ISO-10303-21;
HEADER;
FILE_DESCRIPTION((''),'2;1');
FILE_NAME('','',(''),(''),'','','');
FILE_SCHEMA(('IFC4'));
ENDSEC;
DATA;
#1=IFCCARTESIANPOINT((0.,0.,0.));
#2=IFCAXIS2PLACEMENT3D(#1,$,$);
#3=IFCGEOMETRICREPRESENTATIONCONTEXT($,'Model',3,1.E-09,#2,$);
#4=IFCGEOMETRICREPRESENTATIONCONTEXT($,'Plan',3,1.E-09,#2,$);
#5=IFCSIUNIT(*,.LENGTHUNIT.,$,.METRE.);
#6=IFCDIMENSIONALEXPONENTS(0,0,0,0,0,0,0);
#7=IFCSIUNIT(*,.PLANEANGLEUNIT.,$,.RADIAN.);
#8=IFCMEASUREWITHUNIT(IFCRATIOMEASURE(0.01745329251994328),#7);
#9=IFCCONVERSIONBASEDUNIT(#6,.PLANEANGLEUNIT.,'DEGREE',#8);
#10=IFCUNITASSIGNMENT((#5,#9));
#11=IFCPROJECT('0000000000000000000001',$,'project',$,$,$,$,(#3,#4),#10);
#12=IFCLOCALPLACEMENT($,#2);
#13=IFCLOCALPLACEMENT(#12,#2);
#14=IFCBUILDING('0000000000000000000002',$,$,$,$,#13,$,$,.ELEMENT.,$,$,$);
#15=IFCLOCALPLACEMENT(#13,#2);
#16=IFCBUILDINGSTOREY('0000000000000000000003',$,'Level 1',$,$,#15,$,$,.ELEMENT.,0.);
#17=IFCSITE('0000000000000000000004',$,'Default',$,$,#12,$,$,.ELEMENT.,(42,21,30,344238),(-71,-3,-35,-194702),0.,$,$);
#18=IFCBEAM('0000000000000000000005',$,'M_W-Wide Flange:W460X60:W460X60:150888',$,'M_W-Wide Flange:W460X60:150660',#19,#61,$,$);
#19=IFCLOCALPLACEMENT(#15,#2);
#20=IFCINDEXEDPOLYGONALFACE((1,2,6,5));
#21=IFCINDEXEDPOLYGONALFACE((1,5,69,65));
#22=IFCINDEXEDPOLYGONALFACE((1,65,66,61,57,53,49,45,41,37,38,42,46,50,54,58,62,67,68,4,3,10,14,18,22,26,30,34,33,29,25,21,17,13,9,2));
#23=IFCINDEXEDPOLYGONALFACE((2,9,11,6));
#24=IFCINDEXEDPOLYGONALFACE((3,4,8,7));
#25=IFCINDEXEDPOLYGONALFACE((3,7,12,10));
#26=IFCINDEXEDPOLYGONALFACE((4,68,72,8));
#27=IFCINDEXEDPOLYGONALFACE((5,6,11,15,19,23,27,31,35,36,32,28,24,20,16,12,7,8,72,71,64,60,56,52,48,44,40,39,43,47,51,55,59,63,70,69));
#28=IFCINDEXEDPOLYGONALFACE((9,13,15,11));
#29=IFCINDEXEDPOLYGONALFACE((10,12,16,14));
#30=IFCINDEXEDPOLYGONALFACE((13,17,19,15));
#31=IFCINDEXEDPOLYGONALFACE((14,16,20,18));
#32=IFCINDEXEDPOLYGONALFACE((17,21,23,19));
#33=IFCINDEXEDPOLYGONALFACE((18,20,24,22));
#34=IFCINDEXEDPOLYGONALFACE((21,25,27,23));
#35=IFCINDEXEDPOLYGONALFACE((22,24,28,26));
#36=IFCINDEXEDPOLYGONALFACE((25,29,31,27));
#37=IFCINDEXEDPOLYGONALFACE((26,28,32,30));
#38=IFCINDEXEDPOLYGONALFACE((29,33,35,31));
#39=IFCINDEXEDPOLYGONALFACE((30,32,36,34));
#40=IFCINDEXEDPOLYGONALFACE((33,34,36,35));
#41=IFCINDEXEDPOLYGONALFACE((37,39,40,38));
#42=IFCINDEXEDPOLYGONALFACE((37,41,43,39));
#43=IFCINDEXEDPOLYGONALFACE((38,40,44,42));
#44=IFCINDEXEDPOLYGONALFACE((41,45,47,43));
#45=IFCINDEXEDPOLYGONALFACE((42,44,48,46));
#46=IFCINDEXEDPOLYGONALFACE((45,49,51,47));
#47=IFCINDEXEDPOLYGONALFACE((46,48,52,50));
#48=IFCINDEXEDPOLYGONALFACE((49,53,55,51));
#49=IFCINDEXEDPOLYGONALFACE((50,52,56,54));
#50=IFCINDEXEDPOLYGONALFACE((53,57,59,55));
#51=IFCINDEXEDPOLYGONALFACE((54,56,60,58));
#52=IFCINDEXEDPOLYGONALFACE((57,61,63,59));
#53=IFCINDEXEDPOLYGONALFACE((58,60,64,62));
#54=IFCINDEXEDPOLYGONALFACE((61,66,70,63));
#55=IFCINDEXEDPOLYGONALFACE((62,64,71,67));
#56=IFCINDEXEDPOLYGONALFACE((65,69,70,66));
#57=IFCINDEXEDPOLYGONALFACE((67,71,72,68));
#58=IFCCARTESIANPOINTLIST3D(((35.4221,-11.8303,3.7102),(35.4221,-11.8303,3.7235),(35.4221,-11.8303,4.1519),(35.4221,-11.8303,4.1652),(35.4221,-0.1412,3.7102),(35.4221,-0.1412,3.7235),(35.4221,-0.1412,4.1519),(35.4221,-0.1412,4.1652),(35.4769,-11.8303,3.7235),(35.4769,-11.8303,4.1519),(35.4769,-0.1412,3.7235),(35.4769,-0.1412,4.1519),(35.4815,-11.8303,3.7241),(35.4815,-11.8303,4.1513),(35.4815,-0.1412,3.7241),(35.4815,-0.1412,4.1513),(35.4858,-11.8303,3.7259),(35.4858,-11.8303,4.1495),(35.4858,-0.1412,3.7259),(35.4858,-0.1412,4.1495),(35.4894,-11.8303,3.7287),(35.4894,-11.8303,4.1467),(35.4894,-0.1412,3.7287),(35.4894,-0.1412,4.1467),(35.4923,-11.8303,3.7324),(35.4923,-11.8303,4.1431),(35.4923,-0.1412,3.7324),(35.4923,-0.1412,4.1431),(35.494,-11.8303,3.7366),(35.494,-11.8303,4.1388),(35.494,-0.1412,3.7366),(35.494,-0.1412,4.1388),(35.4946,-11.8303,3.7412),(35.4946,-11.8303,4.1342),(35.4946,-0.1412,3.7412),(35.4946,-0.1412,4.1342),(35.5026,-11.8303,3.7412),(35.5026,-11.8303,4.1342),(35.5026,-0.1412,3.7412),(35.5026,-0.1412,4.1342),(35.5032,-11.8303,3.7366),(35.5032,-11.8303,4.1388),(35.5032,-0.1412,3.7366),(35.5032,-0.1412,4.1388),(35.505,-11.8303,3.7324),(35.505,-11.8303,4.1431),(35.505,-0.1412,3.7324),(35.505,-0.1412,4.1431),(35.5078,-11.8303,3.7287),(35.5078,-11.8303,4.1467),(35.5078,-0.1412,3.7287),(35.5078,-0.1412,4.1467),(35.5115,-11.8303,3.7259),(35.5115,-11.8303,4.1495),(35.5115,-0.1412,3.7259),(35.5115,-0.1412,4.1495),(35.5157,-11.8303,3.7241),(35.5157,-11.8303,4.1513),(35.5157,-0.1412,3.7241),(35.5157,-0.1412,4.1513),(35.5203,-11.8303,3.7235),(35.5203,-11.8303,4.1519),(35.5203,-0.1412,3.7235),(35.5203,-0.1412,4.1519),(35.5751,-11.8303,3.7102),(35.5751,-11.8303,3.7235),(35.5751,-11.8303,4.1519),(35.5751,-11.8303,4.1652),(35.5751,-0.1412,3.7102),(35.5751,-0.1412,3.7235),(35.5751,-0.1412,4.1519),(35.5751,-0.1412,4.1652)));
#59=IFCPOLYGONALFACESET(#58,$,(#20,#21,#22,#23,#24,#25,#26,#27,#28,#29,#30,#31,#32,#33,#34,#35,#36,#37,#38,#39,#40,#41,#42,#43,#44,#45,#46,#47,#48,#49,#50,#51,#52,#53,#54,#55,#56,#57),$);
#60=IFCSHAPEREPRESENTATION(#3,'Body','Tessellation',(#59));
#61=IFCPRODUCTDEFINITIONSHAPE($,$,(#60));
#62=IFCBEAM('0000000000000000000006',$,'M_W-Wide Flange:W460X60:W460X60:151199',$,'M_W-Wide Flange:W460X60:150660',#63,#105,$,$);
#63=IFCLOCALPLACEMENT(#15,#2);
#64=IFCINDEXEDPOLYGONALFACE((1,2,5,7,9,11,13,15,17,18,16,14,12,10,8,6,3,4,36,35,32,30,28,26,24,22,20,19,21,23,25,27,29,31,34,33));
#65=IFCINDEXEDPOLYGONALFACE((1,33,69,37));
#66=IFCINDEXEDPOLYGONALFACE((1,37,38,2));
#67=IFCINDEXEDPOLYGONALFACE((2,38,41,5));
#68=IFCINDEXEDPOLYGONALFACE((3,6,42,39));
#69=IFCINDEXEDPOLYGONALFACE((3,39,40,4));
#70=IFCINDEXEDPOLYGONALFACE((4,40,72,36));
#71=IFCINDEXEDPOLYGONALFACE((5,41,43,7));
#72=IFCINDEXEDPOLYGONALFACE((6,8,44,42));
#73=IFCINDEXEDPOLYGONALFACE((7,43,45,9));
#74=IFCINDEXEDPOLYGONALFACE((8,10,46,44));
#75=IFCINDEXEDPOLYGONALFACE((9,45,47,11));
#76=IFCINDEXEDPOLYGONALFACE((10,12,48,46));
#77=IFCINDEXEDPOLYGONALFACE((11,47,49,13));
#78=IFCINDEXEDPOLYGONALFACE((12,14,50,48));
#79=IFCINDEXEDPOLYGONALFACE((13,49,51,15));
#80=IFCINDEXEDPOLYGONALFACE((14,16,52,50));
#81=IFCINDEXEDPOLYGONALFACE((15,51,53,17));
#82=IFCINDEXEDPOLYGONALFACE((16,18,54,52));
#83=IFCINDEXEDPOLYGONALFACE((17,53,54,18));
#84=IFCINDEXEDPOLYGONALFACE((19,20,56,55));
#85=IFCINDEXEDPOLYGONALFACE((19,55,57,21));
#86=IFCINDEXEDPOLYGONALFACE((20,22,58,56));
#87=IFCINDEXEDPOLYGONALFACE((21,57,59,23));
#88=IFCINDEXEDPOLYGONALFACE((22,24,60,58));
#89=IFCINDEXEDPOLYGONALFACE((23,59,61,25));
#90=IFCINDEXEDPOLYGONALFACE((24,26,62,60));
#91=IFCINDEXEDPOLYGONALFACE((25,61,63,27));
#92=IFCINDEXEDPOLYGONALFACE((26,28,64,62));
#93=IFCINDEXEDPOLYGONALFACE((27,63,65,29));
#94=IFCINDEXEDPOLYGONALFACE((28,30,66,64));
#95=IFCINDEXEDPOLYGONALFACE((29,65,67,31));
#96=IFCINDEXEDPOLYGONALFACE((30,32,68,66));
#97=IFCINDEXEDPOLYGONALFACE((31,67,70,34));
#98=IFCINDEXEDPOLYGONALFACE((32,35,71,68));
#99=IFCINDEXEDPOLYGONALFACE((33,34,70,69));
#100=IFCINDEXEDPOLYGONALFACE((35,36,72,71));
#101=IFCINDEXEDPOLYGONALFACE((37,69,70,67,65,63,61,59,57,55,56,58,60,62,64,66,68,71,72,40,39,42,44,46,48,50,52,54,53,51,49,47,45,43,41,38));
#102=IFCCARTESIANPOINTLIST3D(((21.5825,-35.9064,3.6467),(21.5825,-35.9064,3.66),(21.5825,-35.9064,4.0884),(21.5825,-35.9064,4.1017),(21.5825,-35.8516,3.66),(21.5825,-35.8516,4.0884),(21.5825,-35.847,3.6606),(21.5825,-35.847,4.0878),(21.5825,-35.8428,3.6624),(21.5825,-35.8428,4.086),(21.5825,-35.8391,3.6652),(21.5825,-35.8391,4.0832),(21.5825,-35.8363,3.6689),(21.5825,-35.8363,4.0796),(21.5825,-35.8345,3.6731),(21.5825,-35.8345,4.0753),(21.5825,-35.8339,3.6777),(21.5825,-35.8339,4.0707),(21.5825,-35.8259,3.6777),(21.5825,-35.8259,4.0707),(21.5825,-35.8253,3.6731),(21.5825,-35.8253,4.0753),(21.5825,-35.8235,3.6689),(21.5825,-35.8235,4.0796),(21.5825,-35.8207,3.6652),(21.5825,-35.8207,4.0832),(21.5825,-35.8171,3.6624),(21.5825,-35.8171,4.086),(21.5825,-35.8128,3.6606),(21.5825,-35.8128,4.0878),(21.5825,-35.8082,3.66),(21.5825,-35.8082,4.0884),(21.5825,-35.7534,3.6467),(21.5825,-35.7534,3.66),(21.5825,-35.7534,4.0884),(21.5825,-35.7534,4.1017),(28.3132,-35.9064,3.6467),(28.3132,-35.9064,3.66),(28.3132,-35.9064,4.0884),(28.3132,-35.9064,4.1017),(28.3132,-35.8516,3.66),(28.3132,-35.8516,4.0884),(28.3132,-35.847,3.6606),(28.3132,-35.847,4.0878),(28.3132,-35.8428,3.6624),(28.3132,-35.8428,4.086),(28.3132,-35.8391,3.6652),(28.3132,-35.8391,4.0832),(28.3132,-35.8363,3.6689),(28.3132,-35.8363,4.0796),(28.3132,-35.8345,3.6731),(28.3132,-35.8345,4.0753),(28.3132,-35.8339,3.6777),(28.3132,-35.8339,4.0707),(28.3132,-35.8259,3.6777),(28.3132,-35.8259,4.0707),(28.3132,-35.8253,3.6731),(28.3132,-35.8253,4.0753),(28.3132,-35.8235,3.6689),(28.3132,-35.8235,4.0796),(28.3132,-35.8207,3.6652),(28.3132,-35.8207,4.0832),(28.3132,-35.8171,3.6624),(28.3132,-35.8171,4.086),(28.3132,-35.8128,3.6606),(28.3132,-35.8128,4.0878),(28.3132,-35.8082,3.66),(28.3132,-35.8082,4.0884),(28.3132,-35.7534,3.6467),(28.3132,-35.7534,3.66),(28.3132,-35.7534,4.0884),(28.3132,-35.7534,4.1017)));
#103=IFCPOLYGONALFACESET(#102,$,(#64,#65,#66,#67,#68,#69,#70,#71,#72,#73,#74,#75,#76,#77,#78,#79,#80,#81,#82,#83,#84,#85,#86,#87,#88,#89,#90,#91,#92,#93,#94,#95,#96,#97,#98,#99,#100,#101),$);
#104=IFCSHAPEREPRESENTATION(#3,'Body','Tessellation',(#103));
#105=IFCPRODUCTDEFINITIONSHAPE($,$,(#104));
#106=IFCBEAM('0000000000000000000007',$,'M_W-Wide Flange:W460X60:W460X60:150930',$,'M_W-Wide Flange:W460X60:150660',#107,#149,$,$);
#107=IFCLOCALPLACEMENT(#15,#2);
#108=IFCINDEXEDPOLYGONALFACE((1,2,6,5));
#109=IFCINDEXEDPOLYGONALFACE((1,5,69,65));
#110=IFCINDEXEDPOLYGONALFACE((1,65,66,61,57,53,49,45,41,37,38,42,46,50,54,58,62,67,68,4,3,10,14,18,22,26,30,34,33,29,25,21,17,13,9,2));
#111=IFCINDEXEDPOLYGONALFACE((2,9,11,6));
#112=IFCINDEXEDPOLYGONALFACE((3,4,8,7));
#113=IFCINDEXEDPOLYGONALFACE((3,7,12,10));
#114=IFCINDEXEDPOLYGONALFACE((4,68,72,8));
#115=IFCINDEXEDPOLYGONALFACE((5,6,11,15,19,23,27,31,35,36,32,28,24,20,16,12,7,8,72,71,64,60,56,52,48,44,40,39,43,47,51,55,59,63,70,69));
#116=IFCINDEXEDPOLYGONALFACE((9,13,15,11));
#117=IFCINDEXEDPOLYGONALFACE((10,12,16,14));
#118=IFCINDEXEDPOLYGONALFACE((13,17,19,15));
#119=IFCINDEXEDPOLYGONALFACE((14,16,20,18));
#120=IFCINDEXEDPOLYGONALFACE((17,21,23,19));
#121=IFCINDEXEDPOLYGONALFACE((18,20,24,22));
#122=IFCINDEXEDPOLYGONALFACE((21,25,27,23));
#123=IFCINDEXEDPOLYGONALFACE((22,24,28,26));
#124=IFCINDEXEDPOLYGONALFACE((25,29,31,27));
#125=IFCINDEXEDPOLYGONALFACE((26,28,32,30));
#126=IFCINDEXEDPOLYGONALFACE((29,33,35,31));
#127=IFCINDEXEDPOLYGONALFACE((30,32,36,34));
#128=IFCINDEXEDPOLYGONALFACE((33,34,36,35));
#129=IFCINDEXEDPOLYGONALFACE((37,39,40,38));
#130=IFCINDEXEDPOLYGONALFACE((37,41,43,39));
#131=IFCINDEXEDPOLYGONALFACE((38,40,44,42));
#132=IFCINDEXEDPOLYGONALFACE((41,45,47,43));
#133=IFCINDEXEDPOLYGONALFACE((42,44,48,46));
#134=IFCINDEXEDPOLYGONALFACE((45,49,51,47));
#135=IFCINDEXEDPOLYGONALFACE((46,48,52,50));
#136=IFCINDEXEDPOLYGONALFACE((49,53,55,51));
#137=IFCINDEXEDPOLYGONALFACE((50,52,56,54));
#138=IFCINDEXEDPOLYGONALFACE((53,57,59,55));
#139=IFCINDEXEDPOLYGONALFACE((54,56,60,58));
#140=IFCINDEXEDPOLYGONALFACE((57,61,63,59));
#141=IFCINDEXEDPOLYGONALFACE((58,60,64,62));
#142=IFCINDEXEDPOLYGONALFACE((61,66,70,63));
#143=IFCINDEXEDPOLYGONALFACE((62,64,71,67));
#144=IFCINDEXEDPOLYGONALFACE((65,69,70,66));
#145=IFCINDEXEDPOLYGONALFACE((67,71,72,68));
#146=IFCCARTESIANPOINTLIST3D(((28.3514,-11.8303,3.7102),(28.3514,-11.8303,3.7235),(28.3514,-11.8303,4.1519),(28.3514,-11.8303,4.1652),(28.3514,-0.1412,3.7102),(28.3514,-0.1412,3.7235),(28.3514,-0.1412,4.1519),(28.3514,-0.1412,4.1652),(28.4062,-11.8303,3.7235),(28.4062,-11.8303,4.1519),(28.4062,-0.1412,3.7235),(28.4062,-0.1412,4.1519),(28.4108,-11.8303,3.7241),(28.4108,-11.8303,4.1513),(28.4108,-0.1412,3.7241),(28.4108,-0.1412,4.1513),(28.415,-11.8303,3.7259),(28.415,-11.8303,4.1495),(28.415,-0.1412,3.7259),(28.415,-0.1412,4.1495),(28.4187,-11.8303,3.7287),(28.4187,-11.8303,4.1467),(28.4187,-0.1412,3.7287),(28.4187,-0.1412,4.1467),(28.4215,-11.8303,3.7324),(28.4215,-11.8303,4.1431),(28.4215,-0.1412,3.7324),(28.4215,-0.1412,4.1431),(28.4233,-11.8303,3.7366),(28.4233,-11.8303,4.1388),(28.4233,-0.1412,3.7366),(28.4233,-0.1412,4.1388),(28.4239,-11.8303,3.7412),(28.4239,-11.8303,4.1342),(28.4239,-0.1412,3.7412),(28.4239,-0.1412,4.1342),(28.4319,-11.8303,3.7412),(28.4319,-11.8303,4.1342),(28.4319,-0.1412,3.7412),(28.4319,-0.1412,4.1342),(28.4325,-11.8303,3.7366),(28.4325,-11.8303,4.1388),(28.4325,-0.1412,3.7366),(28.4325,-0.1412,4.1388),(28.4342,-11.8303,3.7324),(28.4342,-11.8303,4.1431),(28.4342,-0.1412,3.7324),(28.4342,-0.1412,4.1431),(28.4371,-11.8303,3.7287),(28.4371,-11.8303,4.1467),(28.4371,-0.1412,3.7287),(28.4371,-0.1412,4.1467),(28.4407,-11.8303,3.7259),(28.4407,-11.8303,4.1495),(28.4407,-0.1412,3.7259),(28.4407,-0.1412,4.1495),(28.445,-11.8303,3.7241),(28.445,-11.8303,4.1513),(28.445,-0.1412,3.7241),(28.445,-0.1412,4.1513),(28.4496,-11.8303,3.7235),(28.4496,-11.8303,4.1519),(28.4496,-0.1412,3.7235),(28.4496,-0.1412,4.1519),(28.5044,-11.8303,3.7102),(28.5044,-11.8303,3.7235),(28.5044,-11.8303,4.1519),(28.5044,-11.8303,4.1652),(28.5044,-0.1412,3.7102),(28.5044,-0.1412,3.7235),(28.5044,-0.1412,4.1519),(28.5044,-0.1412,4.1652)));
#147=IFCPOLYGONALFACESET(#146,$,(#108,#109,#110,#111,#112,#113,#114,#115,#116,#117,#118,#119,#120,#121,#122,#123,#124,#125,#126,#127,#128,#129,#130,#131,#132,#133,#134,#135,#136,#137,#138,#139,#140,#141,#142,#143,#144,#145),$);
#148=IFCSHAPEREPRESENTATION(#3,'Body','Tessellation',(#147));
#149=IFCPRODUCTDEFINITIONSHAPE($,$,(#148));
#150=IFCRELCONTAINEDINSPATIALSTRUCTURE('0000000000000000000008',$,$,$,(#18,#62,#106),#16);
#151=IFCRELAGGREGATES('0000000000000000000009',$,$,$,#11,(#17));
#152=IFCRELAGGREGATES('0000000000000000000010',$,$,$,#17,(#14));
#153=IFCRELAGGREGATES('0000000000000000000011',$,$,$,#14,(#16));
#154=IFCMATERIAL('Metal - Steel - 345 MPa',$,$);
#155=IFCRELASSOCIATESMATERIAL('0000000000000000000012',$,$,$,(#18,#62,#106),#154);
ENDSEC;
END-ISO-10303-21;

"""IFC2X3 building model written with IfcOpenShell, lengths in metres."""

from ifc_helpers import new_model, entity, si_unit, converted_unit, frame, frame_2d, origin, place, context, project, spatial, polyline, circle_curve, parameter, trimmed, segment, composite_curve, outline, extrude, material, element, save


model = new_model("IFC2X3")

# Units and contexts
model_context = context("Model", 3, precision=1e-09, world=origin())
plan_context = context("Plan", 3, precision=1e-09, world=origin())
ifc_project = project(units=[si_unit("LENGTHUNIT", "METRE"), converted_unit("PLANEANGLEUNIT", "DEGREE", entity("IfcRatioMeasure", 0.01745329251994328), si_unit("PLANEANGLEUNIT", "RADIAN"), dimensions=[0, 0, 0, 0, 0, 0, 0])], contexts=[model_context, plan_context])

# Site, building, storey
site_placement = place(None, origin())
site = spatial("IfcSite", under=ifc_project, at=site_placement, Name="Default", CompositionType="ELEMENT", RefLatitude=(42, 21, 30, 344238), RefLongitude=(-71, -3, -35, -194702), RefElevation=0.0)
building_placement = place(site_placement, origin())
building = spatial("IfcBuilding", under=site, at=building_placement, CompositionType="ELEMENT")
storey_placement = place(building_placement, origin())
storey = spatial("IfcBuildingStorey", under=building, at=storey_placement, Name="Level 1", CompositionType="ELEMENT", Elevation=0.0)

# Beams
ifc_material = material(Name="Metal - Steel - 345 MPa")
beam_1_placement = place(storey_placement, frame((35.4986, 0.0, 4.2672), z_axis=(0.0, 0.0, 1.0), x_axis=(-1.0, 0.0, 0.0)))
element("IfcBeam", 1, at=beam_1_placement, inside=storey, material=ifc_material, Name="M_W-Wide Flange:W460X60:W460X60:150888", ObjectType="M_W-Wide Flange:W460X60:150660", context=model_context, shape_type="SweptSolid", body=[
    extrude(outline(composite_curve([segment(polyline([(0.2142, -0.0765), (0.2275, -0.0765)]), True, "CONTINUOUS"), segment(polyline([(0.2275, -0.0765), (0.2275, 0.0765)]), True, "CONTINUOUS"), segment(polyline([(0.2275, 0.0765), (0.2142, 0.0765)]), True, "CONTINUOUS"), segment(polyline([(0.2142, 0.0765), (0.2142, 0.0217)]), True, "CONTINUOUS"), segment(trimmed(circle_curve(frame_2d((0.1965, 0.0217), x_axis=(0.0, 1.0)), 0.0177), [parameter(180.0)], [parameter(270.0)], True, "PARAMETER"), False, "CONTINUOUS"), segment(polyline([(0.1965, 0.004), (-0.1965, 0.004)]), True, "CONTINUOUS"), segment(trimmed(circle_curve(frame_2d((-0.1965, 0.0217), x_axis=(0.0, 1.0)), 0.0177), [parameter(90.0)], [parameter(180.0)], True, "PARAMETER"), False, "CONTINUOUS"), segment(polyline([(-0.2142, 0.0217), (-0.2142, 0.0765)]), True, "CONTINUOUS"), segment(polyline([(-0.2142, 0.0765), (-0.2275, 0.0765)]), True, "CONTINUOUS"), segment(polyline([(-0.2275, 0.0765), (-0.2275, -0.0765)]), True, "CONTINUOUS"), segment(polyline([(-0.2275, -0.0765), (-0.2142, -0.0765)]), True, "CONTINUOUS"), segment(polyline([(-0.2142, -0.0765), (-0.2142, -0.0217)]), True, "CONTINUOUS"), segment(trimmed(circle_curve(frame_2d((-0.1965, -0.0217), x_axis=(0.0, 1.0)), 0.0177), [parameter(360.0)], [parameter(90.0)], True, "PARAMETER"), False, "CONTINUOUS"), segment(polyline([(-0.1965, -0.004), (0.1965, -0.004)]), True, "CONTINUOUS"), segment(trimmed(circle_curve(frame_2d((0.1965, -0.0217), x_axis=(0.0, 1.0)), 0.0177), [parameter(270.0)], [parameter(0.0)], True, "PARAMETER"), False, "CONTINUOUS"), segment(polyline([(0.2142, -0.0217), (0.2142, -0.0765)]), True, "CONTINUOUS")], self_intersect=False)), frame((0.0, 11.8303, -0.3295), z_axis=(0.0, -1.0, 0.0), x_axis=(0.0, 0.0, -1.0)), (0.0, 0.0, 1.0), 11.6891),
])
beam_2_placement = place(storey_placement, frame((28.4279, -35.8299, 4.2672), z_axis=(0.0, 0.0, 1.0), x_axis=(0.0, 1.0, 0.0)))
element("IfcBeam", 2, at=beam_2_placement, inside=storey, material=ifc_material, Name="M_W-Wide Flange:W460X60:W460X60:151199", ObjectType="M_W-Wide Flange:W460X60:150660", context=model_context, shape_type="SweptSolid", body=[
    extrude(outline(composite_curve([segment(polyline([(0.2142, -0.0765), (0.2275, -0.0765)]), True, "CONTINUOUS"), segment(polyline([(0.2275, -0.0765), (0.2275, 0.0765)]), True, "CONTINUOUS"), segment(polyline([(0.2275, 0.0765), (0.2142, 0.0765)]), True, "CONTINUOUS"), segment(polyline([(0.2142, 0.0765), (0.2142, 0.0217)]), True, "CONTINUOUS"), segment(trimmed(circle_curve(frame_2d((0.1965, 0.0217), x_axis=(1.0, 0.0)), 0.0177), [parameter(270.0)], [parameter(360.0)], True, "PARAMETER"), False, "CONTINUOUS"), segment(polyline([(0.1965, 0.004), (-0.1965, 0.004)]), True, "CONTINUOUS"), segment(trimmed(circle_curve(frame_2d((-0.1965, 0.0217), x_axis=(0.0, -1.0)), 0.0177), [parameter(270.0)], [parameter(360.0)], True, "PARAMETER"), False, "CONTINUOUS"), segment(polyline([(-0.2142, 0.0217), (-0.2142, 0.0765)]), True, "CONTINUOUS"), segment(polyline([(-0.2142, 0.0765), (-0.2275, 0.0765)]), True, "CONTINUOUS"), segment(polyline([(-0.2275, 0.0765), (-0.2275, -0.0765)]), True, "CONTINUOUS"), segment(polyline([(-0.2275, -0.0765), (-0.2142, -0.0765)]), True, "CONTINUOUS"), segment(polyline([(-0.2142, -0.0765), (-0.2142, -0.0217)]), True, "CONTINUOUS"), segment(trimmed(circle_curve(frame_2d((-0.1965, -0.0217), x_axis=(-1.0, 0.0)), 0.0177), [parameter(270.0)], [parameter(360.0)], True, "PARAMETER"), False, "CONTINUOUS"), segment(polyline([(-0.1965, -0.004), (0.1965, -0.004)]), True, "CONTINUOUS"), segment(trimmed(circle_curve(frame_2d((0.1965, -0.0217), x_axis=(0.0, 1.0)), 0.0177), [parameter(270.0)], [parameter(0.0)], True, "PARAMETER"), False, "CONTINUOUS"), segment(polyline([(0.2142, -0.0217), (0.2142, -0.0765)]), True, "CONTINUOUS")], self_intersect=False)), frame((0.0, 6.8454, -0.393), z_axis=(0.0, -1.0, 0.0), x_axis=(0.0, 0.0, -1.0)), (0.0, 0.0, 1.0), 6.7307),
])
beam_3_placement = place(storey_placement, frame((28.4279, 0.0, 4.2672), z_axis=(0.0, 0.0, 1.0), x_axis=(-1.0, 0.0, 0.0)))
element("IfcBeam", 3, at=beam_3_placement, inside=storey, material=ifc_material, Name="M_W-Wide Flange:W460X60:W460X60:150930", ObjectType="M_W-Wide Flange:W460X60:150660", context=model_context, shape_type="SweptSolid", body=[
    extrude(outline(composite_curve([segment(polyline([(0.2142, -0.0765), (0.2275, -0.0765)]), True, "CONTINUOUS"), segment(polyline([(0.2275, -0.0765), (0.2275, 0.0765)]), True, "CONTINUOUS"), segment(polyline([(0.2275, 0.0765), (0.2142, 0.0765)]), True, "CONTINUOUS"), segment(polyline([(0.2142, 0.0765), (0.2142, 0.0217)]), True, "CONTINUOUS"), segment(trimmed(circle_curve(frame_2d((0.1965, 0.0217), x_axis=(0.0, 1.0)), 0.0177), [parameter(180.0)], [parameter(270.0)], True, "PARAMETER"), False, "CONTINUOUS"), segment(polyline([(0.1965, 0.004), (-0.1965, 0.004)]), True, "CONTINUOUS"), segment(trimmed(circle_curve(frame_2d((-0.1965, 0.0217), x_axis=(0.0, 1.0)), 0.0177), [parameter(90.0)], [parameter(180.0)], True, "PARAMETER"), False, "CONTINUOUS"), segment(polyline([(-0.2142, 0.0217), (-0.2142, 0.0765)]), True, "CONTINUOUS"), segment(polyline([(-0.2142, 0.0765), (-0.2275, 0.0765)]), True, "CONTINUOUS"), segment(polyline([(-0.2275, 0.0765), (-0.2275, -0.0765)]), True, "CONTINUOUS"), segment(polyline([(-0.2275, -0.0765), (-0.2142, -0.0765)]), True, "CONTINUOUS"), segment(polyline([(-0.2142, -0.0765), (-0.2142, -0.0217)]), True, "CONTINUOUS"), segment(trimmed(circle_curve(frame_2d((-0.1965, -0.0217), x_axis=(0.0, 1.0)), 0.0177), [parameter(360.0)], [parameter(90.0)], True, "PARAMETER"), False, "CONTINUOUS"), segment(polyline([(-0.1965, -0.004), (0.1965, -0.004)]), True, "CONTINUOUS"), segment(trimmed(circle_curve(frame_2d((0.1965, -0.0217), x_axis=(0.0, 1.0)), 0.0177), [parameter(270.0)], [parameter(0.0)], True, "PARAMETER"), False, "CONTINUOUS"), segment(polyline([(0.2142, -0.0217), (0.2142, -0.0765)]), True, "CONTINUOUS")], self_intersect=False)), frame((0.0, 11.8303, -0.3295), z_axis=(0.0, -1.0, 0.0), x_axis=(0.0, 0.0, -1.0)), (0.0, 0.0, 1.0), 11.6891),
])

save(model, "model.ifc")
